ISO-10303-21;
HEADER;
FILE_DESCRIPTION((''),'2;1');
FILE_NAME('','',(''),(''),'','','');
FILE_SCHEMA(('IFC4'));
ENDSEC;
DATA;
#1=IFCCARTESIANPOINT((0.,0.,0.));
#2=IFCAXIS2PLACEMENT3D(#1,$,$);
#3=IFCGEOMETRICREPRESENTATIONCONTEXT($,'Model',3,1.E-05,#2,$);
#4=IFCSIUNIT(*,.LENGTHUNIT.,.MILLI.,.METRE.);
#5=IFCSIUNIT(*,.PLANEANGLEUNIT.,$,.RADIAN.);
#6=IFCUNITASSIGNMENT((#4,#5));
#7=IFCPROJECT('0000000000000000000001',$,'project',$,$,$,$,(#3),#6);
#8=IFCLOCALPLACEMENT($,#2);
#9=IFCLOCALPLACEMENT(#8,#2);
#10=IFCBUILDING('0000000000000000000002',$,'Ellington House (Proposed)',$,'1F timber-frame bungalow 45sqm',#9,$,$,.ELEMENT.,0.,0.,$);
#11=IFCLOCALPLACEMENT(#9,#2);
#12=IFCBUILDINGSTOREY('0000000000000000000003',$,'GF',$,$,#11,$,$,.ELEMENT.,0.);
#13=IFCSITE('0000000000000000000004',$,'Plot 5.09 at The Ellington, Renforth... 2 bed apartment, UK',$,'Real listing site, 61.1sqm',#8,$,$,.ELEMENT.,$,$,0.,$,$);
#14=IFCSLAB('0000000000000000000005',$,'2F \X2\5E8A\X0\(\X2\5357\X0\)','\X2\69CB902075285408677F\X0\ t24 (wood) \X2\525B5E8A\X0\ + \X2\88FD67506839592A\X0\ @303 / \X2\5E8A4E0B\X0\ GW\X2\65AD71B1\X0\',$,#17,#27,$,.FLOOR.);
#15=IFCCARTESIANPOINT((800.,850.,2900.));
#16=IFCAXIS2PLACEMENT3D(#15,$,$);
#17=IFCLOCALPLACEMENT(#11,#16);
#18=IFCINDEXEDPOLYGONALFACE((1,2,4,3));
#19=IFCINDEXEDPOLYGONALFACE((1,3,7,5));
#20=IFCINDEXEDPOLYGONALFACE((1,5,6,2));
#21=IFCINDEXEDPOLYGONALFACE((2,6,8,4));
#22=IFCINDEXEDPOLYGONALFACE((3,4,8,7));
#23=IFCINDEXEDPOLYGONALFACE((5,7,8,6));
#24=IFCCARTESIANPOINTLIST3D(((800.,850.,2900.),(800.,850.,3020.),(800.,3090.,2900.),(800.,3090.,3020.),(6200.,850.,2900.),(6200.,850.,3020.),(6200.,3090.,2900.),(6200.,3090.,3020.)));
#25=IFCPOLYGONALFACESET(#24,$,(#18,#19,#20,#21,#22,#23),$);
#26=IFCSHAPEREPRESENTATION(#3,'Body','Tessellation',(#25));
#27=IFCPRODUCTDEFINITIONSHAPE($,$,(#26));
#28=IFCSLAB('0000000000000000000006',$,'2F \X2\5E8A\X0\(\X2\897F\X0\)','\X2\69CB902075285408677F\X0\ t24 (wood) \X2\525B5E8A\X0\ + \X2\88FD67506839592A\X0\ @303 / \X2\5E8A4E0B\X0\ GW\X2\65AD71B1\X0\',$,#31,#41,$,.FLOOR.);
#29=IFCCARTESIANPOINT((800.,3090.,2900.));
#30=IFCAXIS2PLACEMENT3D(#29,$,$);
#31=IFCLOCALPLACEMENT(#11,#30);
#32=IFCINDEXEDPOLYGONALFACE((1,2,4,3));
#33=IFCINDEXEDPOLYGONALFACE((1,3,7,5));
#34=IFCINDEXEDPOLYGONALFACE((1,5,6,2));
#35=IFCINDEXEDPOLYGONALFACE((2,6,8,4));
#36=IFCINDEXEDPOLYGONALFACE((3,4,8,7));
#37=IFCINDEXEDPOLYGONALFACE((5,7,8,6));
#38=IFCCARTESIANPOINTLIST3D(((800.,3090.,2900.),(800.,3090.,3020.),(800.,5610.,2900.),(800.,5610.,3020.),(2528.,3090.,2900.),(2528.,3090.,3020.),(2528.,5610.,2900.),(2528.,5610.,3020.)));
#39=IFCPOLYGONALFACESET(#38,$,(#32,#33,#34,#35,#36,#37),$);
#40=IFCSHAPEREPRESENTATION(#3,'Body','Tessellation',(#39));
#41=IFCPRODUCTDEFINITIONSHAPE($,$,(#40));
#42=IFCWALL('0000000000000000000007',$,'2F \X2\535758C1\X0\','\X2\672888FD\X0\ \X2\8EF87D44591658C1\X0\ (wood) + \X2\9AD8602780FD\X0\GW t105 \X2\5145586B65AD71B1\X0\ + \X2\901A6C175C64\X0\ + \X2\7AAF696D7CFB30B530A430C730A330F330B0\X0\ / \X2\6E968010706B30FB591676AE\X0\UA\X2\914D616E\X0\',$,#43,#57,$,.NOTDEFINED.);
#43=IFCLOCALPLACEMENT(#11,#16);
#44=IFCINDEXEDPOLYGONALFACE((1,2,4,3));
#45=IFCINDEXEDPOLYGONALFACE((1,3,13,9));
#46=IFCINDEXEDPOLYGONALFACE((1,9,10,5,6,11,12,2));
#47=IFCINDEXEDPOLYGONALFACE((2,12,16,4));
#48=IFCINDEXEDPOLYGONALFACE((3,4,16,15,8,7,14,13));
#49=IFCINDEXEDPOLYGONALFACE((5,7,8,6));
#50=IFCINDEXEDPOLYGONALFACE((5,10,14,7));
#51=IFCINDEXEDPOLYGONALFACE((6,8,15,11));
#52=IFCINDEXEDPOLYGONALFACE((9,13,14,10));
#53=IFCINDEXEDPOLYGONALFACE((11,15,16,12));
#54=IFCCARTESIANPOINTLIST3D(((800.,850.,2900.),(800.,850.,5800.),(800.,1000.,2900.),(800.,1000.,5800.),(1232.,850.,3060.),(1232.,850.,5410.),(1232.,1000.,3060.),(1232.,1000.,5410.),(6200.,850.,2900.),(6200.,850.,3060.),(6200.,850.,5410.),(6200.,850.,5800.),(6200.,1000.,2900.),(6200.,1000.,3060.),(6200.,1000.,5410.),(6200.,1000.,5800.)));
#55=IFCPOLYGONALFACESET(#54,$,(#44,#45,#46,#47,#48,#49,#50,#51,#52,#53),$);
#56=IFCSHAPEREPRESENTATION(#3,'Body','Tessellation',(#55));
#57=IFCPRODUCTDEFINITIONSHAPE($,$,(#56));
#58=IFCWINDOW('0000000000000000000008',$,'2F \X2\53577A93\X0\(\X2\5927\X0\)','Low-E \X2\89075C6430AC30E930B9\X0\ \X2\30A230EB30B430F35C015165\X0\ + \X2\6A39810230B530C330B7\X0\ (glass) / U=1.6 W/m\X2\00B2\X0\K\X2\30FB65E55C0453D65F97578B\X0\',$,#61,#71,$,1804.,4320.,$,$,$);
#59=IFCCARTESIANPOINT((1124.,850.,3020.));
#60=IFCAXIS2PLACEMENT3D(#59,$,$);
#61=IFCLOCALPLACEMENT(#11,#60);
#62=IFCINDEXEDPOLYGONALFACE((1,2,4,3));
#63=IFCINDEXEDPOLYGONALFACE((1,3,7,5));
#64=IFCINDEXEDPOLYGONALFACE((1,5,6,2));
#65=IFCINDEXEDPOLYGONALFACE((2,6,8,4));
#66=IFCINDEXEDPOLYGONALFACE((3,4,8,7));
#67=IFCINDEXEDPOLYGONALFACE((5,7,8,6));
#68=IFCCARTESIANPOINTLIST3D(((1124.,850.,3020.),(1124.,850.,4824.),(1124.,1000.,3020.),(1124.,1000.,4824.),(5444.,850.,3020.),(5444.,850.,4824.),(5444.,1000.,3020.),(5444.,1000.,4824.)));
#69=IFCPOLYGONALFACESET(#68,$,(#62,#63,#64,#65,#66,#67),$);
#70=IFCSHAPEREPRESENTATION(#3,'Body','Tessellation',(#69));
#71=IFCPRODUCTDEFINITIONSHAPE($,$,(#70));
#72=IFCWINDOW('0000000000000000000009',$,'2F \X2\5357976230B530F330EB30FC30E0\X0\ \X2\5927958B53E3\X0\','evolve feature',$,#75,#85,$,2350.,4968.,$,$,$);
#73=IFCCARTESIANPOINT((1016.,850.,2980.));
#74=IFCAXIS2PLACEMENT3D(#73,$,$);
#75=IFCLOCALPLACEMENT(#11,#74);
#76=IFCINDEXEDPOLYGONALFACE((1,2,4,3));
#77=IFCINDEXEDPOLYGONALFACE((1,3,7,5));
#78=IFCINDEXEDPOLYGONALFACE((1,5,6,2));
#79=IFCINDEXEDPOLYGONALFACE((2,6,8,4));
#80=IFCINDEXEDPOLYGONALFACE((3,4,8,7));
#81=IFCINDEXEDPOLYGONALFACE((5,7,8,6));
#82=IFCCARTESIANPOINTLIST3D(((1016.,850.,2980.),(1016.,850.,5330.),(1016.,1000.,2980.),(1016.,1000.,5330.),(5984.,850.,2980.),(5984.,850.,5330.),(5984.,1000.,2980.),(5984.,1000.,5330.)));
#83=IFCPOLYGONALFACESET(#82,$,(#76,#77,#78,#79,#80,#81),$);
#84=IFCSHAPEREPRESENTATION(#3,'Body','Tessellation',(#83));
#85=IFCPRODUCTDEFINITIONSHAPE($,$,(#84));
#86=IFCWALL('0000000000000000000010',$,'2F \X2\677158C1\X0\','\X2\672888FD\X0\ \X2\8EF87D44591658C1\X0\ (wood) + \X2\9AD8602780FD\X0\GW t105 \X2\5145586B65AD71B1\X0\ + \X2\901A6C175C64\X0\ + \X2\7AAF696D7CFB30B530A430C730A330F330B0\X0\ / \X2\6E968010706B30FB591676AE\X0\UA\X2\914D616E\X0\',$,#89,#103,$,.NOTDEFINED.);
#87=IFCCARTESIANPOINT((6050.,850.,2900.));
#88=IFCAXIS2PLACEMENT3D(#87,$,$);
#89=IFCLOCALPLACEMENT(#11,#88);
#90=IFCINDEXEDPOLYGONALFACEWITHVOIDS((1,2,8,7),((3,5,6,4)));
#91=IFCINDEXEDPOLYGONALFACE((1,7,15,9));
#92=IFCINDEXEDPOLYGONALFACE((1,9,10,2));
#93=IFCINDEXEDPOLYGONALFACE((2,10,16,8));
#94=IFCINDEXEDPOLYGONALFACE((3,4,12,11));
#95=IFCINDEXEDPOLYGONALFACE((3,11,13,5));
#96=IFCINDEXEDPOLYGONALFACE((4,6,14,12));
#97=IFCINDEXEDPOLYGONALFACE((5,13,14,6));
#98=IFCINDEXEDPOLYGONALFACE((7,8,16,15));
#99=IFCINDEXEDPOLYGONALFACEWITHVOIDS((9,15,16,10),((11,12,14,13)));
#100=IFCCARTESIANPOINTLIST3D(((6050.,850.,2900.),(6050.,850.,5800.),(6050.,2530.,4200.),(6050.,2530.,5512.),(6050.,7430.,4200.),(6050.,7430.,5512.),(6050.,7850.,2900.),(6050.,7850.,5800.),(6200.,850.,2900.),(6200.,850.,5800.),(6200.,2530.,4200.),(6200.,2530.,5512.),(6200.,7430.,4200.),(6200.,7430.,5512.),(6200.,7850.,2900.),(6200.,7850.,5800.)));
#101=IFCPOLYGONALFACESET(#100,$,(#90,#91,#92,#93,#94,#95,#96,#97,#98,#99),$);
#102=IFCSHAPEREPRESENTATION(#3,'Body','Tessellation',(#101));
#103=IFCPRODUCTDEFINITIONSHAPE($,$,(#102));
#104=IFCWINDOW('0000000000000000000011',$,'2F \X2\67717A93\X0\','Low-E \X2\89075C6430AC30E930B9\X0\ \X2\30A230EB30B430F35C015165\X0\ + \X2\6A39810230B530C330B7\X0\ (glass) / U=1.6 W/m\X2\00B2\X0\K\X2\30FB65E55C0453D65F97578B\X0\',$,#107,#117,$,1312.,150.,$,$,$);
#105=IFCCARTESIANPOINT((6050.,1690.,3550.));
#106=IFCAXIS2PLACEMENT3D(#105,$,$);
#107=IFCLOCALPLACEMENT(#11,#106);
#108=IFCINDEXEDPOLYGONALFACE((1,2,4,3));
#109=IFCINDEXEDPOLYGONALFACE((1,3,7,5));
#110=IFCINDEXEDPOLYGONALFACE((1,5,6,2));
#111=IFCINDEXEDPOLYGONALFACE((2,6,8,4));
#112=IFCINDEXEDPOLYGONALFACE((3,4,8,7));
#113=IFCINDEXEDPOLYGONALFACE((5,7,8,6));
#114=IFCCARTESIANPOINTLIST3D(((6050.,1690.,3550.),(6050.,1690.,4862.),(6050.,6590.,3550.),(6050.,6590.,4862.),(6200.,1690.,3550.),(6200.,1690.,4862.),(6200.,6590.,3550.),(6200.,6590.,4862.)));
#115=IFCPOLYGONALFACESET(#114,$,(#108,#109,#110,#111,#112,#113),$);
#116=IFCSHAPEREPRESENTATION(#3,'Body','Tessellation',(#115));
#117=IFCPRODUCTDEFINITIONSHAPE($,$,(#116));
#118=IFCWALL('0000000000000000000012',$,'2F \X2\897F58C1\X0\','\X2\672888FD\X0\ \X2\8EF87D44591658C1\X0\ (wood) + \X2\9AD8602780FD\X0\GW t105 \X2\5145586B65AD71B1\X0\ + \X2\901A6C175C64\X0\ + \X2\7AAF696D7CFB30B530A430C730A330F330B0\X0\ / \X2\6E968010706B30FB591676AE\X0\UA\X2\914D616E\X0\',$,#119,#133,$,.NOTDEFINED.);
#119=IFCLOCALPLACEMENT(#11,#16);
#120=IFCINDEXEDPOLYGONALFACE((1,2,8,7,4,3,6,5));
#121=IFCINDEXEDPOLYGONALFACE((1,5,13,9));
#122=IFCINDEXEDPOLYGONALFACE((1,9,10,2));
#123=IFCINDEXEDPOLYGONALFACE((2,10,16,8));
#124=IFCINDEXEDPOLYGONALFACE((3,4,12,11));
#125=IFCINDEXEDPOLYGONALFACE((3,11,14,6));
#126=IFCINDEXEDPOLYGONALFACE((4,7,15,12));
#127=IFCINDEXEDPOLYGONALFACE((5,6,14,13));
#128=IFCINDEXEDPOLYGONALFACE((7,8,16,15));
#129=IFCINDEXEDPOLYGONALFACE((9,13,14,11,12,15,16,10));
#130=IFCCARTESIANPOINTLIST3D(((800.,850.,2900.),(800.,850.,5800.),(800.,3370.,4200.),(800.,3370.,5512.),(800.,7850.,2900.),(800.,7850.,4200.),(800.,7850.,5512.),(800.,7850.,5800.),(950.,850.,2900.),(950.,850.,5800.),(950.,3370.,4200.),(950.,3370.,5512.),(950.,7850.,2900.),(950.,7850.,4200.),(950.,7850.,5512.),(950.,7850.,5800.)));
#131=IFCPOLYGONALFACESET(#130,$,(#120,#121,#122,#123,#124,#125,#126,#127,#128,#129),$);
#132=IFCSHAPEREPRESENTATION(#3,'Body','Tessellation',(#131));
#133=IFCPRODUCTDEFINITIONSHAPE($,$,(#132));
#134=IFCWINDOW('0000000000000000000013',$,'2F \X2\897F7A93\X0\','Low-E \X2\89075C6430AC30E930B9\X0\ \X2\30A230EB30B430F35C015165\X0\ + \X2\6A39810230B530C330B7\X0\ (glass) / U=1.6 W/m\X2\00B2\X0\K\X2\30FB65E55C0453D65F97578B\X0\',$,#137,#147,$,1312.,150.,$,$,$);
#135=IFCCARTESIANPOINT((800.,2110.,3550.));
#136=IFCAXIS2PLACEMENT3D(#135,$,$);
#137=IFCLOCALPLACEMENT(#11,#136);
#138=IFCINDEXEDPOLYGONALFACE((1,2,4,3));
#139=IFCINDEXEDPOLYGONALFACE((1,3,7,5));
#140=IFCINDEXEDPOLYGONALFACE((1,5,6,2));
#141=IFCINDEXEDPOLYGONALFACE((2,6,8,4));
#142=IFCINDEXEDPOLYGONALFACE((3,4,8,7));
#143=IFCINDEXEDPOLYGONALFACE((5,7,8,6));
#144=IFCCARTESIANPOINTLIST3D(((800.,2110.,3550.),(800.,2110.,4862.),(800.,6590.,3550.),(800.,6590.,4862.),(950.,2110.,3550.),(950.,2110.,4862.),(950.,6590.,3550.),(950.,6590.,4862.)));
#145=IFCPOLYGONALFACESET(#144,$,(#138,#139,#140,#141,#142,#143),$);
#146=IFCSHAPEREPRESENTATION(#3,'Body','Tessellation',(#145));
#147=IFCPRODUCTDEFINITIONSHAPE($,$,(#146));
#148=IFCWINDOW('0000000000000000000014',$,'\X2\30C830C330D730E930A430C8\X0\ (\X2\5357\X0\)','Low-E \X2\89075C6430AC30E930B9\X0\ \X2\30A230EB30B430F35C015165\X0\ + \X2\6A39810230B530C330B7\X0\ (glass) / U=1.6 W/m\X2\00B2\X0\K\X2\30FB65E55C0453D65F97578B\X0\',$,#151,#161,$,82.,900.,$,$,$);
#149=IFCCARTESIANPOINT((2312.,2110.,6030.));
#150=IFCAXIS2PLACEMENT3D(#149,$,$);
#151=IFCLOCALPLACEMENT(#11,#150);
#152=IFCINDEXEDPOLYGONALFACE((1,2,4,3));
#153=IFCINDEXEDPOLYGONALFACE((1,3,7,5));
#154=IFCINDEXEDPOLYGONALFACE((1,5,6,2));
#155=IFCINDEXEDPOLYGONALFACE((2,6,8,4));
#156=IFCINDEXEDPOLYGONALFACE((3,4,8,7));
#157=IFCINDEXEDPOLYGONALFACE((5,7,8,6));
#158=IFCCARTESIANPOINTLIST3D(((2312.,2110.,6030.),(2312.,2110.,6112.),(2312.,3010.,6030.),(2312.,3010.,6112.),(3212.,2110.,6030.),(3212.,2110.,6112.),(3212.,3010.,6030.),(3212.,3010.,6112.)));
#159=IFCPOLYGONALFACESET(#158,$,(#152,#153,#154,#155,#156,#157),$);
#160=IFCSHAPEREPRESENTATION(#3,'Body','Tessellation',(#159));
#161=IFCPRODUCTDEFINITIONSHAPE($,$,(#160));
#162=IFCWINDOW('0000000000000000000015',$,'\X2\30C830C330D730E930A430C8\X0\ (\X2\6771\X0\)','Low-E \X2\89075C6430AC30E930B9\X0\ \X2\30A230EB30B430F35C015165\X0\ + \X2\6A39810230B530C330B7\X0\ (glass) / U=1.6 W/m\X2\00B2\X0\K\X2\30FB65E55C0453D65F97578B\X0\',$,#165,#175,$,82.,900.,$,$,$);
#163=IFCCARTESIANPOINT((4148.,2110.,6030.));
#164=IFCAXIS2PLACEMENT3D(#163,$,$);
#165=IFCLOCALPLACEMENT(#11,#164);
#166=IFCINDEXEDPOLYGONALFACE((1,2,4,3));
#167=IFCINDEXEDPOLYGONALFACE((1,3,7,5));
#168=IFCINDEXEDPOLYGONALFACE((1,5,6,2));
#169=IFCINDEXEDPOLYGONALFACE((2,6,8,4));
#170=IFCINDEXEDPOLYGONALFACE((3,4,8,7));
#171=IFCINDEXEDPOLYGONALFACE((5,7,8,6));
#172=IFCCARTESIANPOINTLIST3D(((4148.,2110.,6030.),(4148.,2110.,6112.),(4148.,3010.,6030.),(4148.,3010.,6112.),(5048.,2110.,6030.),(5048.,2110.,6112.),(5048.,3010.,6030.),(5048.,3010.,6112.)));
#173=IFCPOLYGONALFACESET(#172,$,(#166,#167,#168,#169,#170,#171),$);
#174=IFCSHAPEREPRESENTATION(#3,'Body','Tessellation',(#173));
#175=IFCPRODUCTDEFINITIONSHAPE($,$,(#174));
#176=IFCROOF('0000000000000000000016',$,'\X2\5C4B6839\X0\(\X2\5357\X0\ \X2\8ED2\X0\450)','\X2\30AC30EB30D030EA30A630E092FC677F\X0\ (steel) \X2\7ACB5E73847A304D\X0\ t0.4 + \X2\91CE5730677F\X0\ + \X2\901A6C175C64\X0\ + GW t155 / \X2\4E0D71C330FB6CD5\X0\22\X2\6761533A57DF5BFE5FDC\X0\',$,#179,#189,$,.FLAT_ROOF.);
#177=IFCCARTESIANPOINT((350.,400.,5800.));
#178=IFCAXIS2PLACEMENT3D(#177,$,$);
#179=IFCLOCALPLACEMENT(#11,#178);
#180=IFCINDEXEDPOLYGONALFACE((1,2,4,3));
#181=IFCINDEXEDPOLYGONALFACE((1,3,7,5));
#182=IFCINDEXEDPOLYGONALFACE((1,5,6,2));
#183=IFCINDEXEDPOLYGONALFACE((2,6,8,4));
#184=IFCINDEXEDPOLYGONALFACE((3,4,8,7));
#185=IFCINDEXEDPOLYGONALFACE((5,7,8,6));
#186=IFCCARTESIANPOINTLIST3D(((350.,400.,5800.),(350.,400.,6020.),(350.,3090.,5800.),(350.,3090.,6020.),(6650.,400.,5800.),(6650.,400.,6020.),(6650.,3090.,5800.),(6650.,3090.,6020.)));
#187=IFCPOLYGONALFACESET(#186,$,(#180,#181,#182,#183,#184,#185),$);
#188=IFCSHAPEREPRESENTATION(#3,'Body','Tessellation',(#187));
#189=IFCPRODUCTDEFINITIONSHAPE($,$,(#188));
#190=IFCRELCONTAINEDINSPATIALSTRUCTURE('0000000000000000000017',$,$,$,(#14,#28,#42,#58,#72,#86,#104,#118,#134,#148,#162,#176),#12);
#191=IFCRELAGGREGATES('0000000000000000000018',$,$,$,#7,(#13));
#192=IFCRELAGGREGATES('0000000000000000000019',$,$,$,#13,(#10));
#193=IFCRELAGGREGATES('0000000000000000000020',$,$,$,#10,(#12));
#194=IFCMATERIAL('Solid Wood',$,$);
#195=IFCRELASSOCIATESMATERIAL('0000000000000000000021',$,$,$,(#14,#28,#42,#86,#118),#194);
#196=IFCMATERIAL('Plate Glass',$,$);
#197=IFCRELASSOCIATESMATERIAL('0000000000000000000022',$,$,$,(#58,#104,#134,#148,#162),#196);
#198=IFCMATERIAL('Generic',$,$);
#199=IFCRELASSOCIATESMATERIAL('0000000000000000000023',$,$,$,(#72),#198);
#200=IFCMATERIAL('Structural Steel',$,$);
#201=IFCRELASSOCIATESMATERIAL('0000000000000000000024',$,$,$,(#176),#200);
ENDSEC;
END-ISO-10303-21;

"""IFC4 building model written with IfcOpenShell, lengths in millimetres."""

from ifc_helpers import new_model, si_unit, frame, frame_2d, origin, place, context, project, spatial, rectangle, extrude, material, element, fill, save


model = new_model("IFC4")

# Units and contexts
model_context = context("Model", 3, precision=1e-05, world=origin())
ifc_project = project(units=[si_unit("LENGTHUNIT", "METRE", prefix="MILLI"), si_unit("PLANEANGLEUNIT", "RADIAN")], contexts=[model_context])

# Site, building, storey
site_placement = place(None, origin())
site = spatial("IfcSite", under=ifc_project, at=site_placement, Name="Plot 5.09 at The Ellington, Renforth... 2 bed apartment, UK", ObjectType="Real listing site, 61.1sqm", CompositionType="ELEMENT", RefElevation=0.0)
building_placement = place(site_placement, origin())
building = spatial("IfcBuilding", under=site, at=building_placement, Name="Ellington House (Proposed)", ObjectType="1F timber-frame bungalow 45sqm", CompositionType="ELEMENT", ElevationOfRefHeight=0.0, ElevationOfTerrain=0.0)
storey_placement = place(building_placement, origin())
storey = spatial("IfcBuildingStorey", under=building, at=storey_placement, Name="GF", CompositionType="ELEMENT", Elevation=0.0)

# Slabs
ifc_material_1 = material(Name="Solid Wood")
slab_1_placement = place(storey_placement, frame((800.0, 850.0, 2900.0)))
element("IfcSlab", 1, at=slab_1_placement, inside=storey, material=ifc_material_1, Name="2F 床(南)", Description="構造用合板 t24 (wood) 剛床 + 製材根太 @303 / 床下 GW断熱", PredefinedType="FLOOR", context=model_context, shape_type="SweptSolid", body=[
    extrude(rectangle(XDim=5400.0, YDim=2240.0, at=frame_2d((2700.0, 1120.0))), frame((800.0, 850.0, 2900.0)), (0.0, 0.0, 1.0), 120.0),
])
slab_2_placement = place(storey_placement, frame((800.0, 3090.0, 2900.0)))
element("IfcSlab", 2, at=slab_2_placement, inside=storey, material=ifc_material_1, Name="2F 床(西)", Description="構造用合板 t24 (wood) 剛床 + 製材根太 @303 / 床下 GW断熱", PredefinedType="FLOOR", context=model_context, shape_type="SweptSolid", body=[
    extrude(rectangle(XDim=1728.0, YDim=2520.0, at=frame_2d((864.0, 1260.0))), frame((800.0, 3090.0, 2900.0)), (0.0, 0.0, 1.0), 120.0),
])

# Wall, openings, windows
wall_1_placement = place(storey_placement, frame((800.0, 850.0, 2900.0)))
wall_1 = element("IfcWall", 3, at=wall_1_placement, inside=storey, material=ifc_material_1, Name="2F 南壁", Description="木製 軸組外壁 (wood) + 高性能GW t105 充填断熱 + 通気層 + 窯業系サイディング / 準耐火・外皮UA配慮", PredefinedType="NOTDEFINED", context=model_context, shape_type="SweptSolid", body=[
    extrude(rectangle(XDim=5400.0, YDim=150.0, at=frame_2d((2700.0, 75.0))), frame((800.0, 850.0, 2900.0)), (0.0, 0.0, 1.0), 2900.0),
])
opening_1_placement = place(storey_placement, frame((1124.0, 850.0, 3020.0)))
opening_1 = element("IfcOpeningElement", 4, at=opening_1_placement, cuts=wall_1, PredefinedType="NOTDEFINED", context=model_context, shape_type="SweptSolid", body=[
    extrude(rectangle(XDim=4320.0, YDim=150.0, at=frame_2d((2160.0, 75.0))), frame((1124.0, 850.0, 3020.0)), (0.0, 0.0, 1.0), 1804.0),
])
opening_2_placement = place(storey_placement, frame((1016.0, 850.0, 2980.0)))
opening_2 = element("IfcOpeningElement", 5, at=opening_2_placement, cuts=wall_1, PredefinedType="NOTDEFINED", context=model_context, shape_type="SweptSolid", body=[
    extrude(rectangle(XDim=4968.0, YDim=150.0, at=frame_2d((2484.0, 75.0))), frame((1016.0, 850.0, 2980.0)), (0.0, 0.0, 1.0), 2350.0),
])
ifc_material_2 = material(Name="Plate Glass")
window_1_placement = place(storey_placement, frame((1124.0, 850.0, 3020.0)))
window_1 = element("IfcWindow", 6, at=window_1_placement, inside=storey, material=ifc_material_2, Name="2F 南窓(大)", Description="Low-E 複層ガラス アルゴン封入 + 樹脂サッシ (glass) / U=1.6 W/m²K・日射取得型", OverallHeight=1804.0, OverallWidth=4320.0, context=model_context, shape_type="SweptSolid", body=[
    extrude(rectangle(XDim=4320.0, YDim=150.0, at=frame_2d((2160.0, 75.0))), frame((1124.0, 850.0, 3020.0)), (0.0, 0.0, 1.0), 1804.0),
])
fill(opening_1, window_1)
ifc_material_3 = material(Name="Generic")
window_2_placement = place(storey_placement, frame((1016.0, 850.0, 2980.0)))
window_2 = element("IfcWindow", 7, at=window_2_placement, inside=storey, material=ifc_material_3, Name="2F 南面サンルーム 大開口", Description="evolve feature", OverallHeight=2350.0, OverallWidth=4968.0, context=model_context, shape_type="SweptSolid", body=[
    extrude(rectangle(XDim=4968.0, YDim=150.0, at=frame_2d((2484.0, 75.0))), frame((1016.0, 850.0, 2980.0)), (0.0, 0.0, 1.0), 2350.0),
])
fill(opening_2, window_2)

# Walls, openings, windows
wall_2_placement = place(storey_placement, frame((6050.0, 850.0, 2900.0)))
wall_2 = element("IfcWall", 8, at=wall_2_placement, inside=storey, material=ifc_material_1, Name="2F 東壁", Description="木製 軸組外壁 (wood) + 高性能GW t105 充填断熱 + 通気層 + 窯業系サイディング / 準耐火・外皮UA配慮", PredefinedType="NOTDEFINED", context=model_context, shape_type="SweptSolid", body=[
    extrude(rectangle(XDim=150.0, YDim=7000.0, at=frame_2d((75.0, 3500.0))), frame((6050.0, 850.0, 2900.0)), (0.0, 0.0, 1.0), 2900.0),
])
opening_3_placement = place(storey_placement, frame((6050.0, 1690.0, 3550.0)))
opening_3 = element("IfcOpeningElement", 9, at=opening_3_placement, cuts=wall_2, PredefinedType="NOTDEFINED", context=model_context, shape_type="SweptSolid", body=[
    extrude(rectangle(XDim=150.0, YDim=4900.0, at=frame_2d((75.0, 2450.0))), frame((6050.0, 1690.0, 3550.0)), (0.0, 0.0, 1.0), 1312.0),
])
window_3_placement = place(storey_placement, frame((6050.0, 1690.0, 3550.0)))
window_3 = element("IfcWindow", 10, at=window_3_placement, inside=storey, material=ifc_material_2, Name="2F 東窓", Description="Low-E 複層ガラス アルゴン封入 + 樹脂サッシ (glass) / U=1.6 W/m²K・日射取得型", OverallHeight=1312.0, OverallWidth=150.0, context=model_context, shape_type="SweptSolid", body=[
    extrude(rectangle(XDim=150.0, YDim=4900.0, at=frame_2d((75.0, 2450.0))), frame((6050.0, 1690.0, 3550.0)), (0.0, 0.0, 1.0), 1312.0),
])
fill(opening_3, window_3)
wall_3_placement = place(storey_placement, frame((800.0, 850.0, 2900.0)))
wall_3 = element("IfcWall", 11, at=wall_3_placement, inside=storey, material=ifc_material_1, Name="2F 西壁", Description="木製 軸組外壁 (wood) + 高性能GW t105 充填断熱 + 通気層 + 窯業系サイディング / 準耐火・外皮UA配慮", PredefinedType="NOTDEFINED", context=model_context, shape_type="SweptSolid", body=[
    extrude(rectangle(XDim=150.0, YDim=7000.0, at=frame_2d((75.0, 3500.0))), frame((800.0, 850.0, 2900.0)), (0.0, 0.0, 1.0), 2900.0),
])
opening_4_placement = place(storey_placement, frame((800.0, 2110.0, 3550.0)))
opening_4 = element("IfcOpeningElement", 12, at=opening_4_placement, cuts=wall_3, PredefinedType="NOTDEFINED", context=model_context, shape_type="SweptSolid", body=[
    extrude(rectangle(XDim=150.0, YDim=4480.0, at=frame_2d((75.0, 2240.0))), frame((800.0, 2110.0, 3550.0)), (0.0, 0.0, 1.0), 1312.0),
])
window_4_placement = place(storey_placement, frame((800.0, 2110.0, 3550.0)))
window_4 = element("IfcWindow", 13, at=window_4_placement, inside=storey, material=ifc_material_2, Name="2F 西窓", Description="Low-E 複層ガラス アルゴン封入 + 樹脂サッシ (glass) / U=1.6 W/m²K・日射取得型", OverallHeight=1312.0, OverallWidth=150.0, context=model_context, shape_type="SweptSolid", body=[
    extrude(rectangle(XDim=150.0, YDim=4480.0, at=frame_2d((75.0, 2240.0))), frame((800.0, 2110.0, 3550.0)), (0.0, 0.0, 1.0), 1312.0),
])
fill(opening_4, window_4)

# Windows
window_5_placement = place(storey_placement, frame((2312.0, 2110.0, 6030.0)))
element("IfcWindow", 14, at=window_5_placement, inside=storey, material=ifc_material_2, Name="トップライト (南)", Description="Low-E 複層ガラス アルゴン封入 + 樹脂サッシ (glass) / U=1.6 W/m²K・日射取得型", OverallHeight=82.0, OverallWidth=900.0, context=model_context, shape_type="SweptSolid", body=[
    extrude(rectangle(XDim=900.0, YDim=900.0, at=frame_2d((450.0, 450.0))), frame((2312.0, 2110.0, 6030.0)), (0.0, 0.0, 1.0), 82.0),
])
window_6_placement = place(storey_placement, frame((4148.0, 2110.0, 6030.0)))
element("IfcWindow", 15, at=window_6_placement, inside=storey, material=ifc_material_2, Name="トップライト (東)", Description="Low-E 複層ガラス アルゴン封入 + 樹脂サッシ (glass) / U=1.6 W/m²K・日射取得型", OverallHeight=82.0, OverallWidth=900.0, context=model_context, shape_type="SweptSolid", body=[
    extrude(rectangle(XDim=900.0, YDim=900.0, at=frame_2d((450.0, 450.0))), frame((4148.0, 2110.0, 6030.0)), (0.0, 0.0, 1.0), 82.0),
])

# Roof
ifc_material_4 = material(Name="Structural Steel")
roof_1_placement = place(storey_placement, frame((350.0, 400.0, 5800.0)))
element("IfcRoof", 16, at=roof_1_placement, inside=storey, material=ifc_material_4, Name="屋根(南 軒450)", Description="ガルバリウム鋼板 (steel) 立平葺き t0.4 + 野地板 + 通気層 + GW t155 / 不燃・法22条区域対応", PredefinedType="FLAT_ROOF", context=model_context, shape_type="SweptSolid", body=[
    extrude(rectangle(XDim=6300.0, YDim=2690.0, at=frame_2d((3150.0, 1345.0))), frame((350.0, 400.0, 5800.0)), (0.0, 0.0, 1.0), 220.0),
])

save(model, "model.ifc")
